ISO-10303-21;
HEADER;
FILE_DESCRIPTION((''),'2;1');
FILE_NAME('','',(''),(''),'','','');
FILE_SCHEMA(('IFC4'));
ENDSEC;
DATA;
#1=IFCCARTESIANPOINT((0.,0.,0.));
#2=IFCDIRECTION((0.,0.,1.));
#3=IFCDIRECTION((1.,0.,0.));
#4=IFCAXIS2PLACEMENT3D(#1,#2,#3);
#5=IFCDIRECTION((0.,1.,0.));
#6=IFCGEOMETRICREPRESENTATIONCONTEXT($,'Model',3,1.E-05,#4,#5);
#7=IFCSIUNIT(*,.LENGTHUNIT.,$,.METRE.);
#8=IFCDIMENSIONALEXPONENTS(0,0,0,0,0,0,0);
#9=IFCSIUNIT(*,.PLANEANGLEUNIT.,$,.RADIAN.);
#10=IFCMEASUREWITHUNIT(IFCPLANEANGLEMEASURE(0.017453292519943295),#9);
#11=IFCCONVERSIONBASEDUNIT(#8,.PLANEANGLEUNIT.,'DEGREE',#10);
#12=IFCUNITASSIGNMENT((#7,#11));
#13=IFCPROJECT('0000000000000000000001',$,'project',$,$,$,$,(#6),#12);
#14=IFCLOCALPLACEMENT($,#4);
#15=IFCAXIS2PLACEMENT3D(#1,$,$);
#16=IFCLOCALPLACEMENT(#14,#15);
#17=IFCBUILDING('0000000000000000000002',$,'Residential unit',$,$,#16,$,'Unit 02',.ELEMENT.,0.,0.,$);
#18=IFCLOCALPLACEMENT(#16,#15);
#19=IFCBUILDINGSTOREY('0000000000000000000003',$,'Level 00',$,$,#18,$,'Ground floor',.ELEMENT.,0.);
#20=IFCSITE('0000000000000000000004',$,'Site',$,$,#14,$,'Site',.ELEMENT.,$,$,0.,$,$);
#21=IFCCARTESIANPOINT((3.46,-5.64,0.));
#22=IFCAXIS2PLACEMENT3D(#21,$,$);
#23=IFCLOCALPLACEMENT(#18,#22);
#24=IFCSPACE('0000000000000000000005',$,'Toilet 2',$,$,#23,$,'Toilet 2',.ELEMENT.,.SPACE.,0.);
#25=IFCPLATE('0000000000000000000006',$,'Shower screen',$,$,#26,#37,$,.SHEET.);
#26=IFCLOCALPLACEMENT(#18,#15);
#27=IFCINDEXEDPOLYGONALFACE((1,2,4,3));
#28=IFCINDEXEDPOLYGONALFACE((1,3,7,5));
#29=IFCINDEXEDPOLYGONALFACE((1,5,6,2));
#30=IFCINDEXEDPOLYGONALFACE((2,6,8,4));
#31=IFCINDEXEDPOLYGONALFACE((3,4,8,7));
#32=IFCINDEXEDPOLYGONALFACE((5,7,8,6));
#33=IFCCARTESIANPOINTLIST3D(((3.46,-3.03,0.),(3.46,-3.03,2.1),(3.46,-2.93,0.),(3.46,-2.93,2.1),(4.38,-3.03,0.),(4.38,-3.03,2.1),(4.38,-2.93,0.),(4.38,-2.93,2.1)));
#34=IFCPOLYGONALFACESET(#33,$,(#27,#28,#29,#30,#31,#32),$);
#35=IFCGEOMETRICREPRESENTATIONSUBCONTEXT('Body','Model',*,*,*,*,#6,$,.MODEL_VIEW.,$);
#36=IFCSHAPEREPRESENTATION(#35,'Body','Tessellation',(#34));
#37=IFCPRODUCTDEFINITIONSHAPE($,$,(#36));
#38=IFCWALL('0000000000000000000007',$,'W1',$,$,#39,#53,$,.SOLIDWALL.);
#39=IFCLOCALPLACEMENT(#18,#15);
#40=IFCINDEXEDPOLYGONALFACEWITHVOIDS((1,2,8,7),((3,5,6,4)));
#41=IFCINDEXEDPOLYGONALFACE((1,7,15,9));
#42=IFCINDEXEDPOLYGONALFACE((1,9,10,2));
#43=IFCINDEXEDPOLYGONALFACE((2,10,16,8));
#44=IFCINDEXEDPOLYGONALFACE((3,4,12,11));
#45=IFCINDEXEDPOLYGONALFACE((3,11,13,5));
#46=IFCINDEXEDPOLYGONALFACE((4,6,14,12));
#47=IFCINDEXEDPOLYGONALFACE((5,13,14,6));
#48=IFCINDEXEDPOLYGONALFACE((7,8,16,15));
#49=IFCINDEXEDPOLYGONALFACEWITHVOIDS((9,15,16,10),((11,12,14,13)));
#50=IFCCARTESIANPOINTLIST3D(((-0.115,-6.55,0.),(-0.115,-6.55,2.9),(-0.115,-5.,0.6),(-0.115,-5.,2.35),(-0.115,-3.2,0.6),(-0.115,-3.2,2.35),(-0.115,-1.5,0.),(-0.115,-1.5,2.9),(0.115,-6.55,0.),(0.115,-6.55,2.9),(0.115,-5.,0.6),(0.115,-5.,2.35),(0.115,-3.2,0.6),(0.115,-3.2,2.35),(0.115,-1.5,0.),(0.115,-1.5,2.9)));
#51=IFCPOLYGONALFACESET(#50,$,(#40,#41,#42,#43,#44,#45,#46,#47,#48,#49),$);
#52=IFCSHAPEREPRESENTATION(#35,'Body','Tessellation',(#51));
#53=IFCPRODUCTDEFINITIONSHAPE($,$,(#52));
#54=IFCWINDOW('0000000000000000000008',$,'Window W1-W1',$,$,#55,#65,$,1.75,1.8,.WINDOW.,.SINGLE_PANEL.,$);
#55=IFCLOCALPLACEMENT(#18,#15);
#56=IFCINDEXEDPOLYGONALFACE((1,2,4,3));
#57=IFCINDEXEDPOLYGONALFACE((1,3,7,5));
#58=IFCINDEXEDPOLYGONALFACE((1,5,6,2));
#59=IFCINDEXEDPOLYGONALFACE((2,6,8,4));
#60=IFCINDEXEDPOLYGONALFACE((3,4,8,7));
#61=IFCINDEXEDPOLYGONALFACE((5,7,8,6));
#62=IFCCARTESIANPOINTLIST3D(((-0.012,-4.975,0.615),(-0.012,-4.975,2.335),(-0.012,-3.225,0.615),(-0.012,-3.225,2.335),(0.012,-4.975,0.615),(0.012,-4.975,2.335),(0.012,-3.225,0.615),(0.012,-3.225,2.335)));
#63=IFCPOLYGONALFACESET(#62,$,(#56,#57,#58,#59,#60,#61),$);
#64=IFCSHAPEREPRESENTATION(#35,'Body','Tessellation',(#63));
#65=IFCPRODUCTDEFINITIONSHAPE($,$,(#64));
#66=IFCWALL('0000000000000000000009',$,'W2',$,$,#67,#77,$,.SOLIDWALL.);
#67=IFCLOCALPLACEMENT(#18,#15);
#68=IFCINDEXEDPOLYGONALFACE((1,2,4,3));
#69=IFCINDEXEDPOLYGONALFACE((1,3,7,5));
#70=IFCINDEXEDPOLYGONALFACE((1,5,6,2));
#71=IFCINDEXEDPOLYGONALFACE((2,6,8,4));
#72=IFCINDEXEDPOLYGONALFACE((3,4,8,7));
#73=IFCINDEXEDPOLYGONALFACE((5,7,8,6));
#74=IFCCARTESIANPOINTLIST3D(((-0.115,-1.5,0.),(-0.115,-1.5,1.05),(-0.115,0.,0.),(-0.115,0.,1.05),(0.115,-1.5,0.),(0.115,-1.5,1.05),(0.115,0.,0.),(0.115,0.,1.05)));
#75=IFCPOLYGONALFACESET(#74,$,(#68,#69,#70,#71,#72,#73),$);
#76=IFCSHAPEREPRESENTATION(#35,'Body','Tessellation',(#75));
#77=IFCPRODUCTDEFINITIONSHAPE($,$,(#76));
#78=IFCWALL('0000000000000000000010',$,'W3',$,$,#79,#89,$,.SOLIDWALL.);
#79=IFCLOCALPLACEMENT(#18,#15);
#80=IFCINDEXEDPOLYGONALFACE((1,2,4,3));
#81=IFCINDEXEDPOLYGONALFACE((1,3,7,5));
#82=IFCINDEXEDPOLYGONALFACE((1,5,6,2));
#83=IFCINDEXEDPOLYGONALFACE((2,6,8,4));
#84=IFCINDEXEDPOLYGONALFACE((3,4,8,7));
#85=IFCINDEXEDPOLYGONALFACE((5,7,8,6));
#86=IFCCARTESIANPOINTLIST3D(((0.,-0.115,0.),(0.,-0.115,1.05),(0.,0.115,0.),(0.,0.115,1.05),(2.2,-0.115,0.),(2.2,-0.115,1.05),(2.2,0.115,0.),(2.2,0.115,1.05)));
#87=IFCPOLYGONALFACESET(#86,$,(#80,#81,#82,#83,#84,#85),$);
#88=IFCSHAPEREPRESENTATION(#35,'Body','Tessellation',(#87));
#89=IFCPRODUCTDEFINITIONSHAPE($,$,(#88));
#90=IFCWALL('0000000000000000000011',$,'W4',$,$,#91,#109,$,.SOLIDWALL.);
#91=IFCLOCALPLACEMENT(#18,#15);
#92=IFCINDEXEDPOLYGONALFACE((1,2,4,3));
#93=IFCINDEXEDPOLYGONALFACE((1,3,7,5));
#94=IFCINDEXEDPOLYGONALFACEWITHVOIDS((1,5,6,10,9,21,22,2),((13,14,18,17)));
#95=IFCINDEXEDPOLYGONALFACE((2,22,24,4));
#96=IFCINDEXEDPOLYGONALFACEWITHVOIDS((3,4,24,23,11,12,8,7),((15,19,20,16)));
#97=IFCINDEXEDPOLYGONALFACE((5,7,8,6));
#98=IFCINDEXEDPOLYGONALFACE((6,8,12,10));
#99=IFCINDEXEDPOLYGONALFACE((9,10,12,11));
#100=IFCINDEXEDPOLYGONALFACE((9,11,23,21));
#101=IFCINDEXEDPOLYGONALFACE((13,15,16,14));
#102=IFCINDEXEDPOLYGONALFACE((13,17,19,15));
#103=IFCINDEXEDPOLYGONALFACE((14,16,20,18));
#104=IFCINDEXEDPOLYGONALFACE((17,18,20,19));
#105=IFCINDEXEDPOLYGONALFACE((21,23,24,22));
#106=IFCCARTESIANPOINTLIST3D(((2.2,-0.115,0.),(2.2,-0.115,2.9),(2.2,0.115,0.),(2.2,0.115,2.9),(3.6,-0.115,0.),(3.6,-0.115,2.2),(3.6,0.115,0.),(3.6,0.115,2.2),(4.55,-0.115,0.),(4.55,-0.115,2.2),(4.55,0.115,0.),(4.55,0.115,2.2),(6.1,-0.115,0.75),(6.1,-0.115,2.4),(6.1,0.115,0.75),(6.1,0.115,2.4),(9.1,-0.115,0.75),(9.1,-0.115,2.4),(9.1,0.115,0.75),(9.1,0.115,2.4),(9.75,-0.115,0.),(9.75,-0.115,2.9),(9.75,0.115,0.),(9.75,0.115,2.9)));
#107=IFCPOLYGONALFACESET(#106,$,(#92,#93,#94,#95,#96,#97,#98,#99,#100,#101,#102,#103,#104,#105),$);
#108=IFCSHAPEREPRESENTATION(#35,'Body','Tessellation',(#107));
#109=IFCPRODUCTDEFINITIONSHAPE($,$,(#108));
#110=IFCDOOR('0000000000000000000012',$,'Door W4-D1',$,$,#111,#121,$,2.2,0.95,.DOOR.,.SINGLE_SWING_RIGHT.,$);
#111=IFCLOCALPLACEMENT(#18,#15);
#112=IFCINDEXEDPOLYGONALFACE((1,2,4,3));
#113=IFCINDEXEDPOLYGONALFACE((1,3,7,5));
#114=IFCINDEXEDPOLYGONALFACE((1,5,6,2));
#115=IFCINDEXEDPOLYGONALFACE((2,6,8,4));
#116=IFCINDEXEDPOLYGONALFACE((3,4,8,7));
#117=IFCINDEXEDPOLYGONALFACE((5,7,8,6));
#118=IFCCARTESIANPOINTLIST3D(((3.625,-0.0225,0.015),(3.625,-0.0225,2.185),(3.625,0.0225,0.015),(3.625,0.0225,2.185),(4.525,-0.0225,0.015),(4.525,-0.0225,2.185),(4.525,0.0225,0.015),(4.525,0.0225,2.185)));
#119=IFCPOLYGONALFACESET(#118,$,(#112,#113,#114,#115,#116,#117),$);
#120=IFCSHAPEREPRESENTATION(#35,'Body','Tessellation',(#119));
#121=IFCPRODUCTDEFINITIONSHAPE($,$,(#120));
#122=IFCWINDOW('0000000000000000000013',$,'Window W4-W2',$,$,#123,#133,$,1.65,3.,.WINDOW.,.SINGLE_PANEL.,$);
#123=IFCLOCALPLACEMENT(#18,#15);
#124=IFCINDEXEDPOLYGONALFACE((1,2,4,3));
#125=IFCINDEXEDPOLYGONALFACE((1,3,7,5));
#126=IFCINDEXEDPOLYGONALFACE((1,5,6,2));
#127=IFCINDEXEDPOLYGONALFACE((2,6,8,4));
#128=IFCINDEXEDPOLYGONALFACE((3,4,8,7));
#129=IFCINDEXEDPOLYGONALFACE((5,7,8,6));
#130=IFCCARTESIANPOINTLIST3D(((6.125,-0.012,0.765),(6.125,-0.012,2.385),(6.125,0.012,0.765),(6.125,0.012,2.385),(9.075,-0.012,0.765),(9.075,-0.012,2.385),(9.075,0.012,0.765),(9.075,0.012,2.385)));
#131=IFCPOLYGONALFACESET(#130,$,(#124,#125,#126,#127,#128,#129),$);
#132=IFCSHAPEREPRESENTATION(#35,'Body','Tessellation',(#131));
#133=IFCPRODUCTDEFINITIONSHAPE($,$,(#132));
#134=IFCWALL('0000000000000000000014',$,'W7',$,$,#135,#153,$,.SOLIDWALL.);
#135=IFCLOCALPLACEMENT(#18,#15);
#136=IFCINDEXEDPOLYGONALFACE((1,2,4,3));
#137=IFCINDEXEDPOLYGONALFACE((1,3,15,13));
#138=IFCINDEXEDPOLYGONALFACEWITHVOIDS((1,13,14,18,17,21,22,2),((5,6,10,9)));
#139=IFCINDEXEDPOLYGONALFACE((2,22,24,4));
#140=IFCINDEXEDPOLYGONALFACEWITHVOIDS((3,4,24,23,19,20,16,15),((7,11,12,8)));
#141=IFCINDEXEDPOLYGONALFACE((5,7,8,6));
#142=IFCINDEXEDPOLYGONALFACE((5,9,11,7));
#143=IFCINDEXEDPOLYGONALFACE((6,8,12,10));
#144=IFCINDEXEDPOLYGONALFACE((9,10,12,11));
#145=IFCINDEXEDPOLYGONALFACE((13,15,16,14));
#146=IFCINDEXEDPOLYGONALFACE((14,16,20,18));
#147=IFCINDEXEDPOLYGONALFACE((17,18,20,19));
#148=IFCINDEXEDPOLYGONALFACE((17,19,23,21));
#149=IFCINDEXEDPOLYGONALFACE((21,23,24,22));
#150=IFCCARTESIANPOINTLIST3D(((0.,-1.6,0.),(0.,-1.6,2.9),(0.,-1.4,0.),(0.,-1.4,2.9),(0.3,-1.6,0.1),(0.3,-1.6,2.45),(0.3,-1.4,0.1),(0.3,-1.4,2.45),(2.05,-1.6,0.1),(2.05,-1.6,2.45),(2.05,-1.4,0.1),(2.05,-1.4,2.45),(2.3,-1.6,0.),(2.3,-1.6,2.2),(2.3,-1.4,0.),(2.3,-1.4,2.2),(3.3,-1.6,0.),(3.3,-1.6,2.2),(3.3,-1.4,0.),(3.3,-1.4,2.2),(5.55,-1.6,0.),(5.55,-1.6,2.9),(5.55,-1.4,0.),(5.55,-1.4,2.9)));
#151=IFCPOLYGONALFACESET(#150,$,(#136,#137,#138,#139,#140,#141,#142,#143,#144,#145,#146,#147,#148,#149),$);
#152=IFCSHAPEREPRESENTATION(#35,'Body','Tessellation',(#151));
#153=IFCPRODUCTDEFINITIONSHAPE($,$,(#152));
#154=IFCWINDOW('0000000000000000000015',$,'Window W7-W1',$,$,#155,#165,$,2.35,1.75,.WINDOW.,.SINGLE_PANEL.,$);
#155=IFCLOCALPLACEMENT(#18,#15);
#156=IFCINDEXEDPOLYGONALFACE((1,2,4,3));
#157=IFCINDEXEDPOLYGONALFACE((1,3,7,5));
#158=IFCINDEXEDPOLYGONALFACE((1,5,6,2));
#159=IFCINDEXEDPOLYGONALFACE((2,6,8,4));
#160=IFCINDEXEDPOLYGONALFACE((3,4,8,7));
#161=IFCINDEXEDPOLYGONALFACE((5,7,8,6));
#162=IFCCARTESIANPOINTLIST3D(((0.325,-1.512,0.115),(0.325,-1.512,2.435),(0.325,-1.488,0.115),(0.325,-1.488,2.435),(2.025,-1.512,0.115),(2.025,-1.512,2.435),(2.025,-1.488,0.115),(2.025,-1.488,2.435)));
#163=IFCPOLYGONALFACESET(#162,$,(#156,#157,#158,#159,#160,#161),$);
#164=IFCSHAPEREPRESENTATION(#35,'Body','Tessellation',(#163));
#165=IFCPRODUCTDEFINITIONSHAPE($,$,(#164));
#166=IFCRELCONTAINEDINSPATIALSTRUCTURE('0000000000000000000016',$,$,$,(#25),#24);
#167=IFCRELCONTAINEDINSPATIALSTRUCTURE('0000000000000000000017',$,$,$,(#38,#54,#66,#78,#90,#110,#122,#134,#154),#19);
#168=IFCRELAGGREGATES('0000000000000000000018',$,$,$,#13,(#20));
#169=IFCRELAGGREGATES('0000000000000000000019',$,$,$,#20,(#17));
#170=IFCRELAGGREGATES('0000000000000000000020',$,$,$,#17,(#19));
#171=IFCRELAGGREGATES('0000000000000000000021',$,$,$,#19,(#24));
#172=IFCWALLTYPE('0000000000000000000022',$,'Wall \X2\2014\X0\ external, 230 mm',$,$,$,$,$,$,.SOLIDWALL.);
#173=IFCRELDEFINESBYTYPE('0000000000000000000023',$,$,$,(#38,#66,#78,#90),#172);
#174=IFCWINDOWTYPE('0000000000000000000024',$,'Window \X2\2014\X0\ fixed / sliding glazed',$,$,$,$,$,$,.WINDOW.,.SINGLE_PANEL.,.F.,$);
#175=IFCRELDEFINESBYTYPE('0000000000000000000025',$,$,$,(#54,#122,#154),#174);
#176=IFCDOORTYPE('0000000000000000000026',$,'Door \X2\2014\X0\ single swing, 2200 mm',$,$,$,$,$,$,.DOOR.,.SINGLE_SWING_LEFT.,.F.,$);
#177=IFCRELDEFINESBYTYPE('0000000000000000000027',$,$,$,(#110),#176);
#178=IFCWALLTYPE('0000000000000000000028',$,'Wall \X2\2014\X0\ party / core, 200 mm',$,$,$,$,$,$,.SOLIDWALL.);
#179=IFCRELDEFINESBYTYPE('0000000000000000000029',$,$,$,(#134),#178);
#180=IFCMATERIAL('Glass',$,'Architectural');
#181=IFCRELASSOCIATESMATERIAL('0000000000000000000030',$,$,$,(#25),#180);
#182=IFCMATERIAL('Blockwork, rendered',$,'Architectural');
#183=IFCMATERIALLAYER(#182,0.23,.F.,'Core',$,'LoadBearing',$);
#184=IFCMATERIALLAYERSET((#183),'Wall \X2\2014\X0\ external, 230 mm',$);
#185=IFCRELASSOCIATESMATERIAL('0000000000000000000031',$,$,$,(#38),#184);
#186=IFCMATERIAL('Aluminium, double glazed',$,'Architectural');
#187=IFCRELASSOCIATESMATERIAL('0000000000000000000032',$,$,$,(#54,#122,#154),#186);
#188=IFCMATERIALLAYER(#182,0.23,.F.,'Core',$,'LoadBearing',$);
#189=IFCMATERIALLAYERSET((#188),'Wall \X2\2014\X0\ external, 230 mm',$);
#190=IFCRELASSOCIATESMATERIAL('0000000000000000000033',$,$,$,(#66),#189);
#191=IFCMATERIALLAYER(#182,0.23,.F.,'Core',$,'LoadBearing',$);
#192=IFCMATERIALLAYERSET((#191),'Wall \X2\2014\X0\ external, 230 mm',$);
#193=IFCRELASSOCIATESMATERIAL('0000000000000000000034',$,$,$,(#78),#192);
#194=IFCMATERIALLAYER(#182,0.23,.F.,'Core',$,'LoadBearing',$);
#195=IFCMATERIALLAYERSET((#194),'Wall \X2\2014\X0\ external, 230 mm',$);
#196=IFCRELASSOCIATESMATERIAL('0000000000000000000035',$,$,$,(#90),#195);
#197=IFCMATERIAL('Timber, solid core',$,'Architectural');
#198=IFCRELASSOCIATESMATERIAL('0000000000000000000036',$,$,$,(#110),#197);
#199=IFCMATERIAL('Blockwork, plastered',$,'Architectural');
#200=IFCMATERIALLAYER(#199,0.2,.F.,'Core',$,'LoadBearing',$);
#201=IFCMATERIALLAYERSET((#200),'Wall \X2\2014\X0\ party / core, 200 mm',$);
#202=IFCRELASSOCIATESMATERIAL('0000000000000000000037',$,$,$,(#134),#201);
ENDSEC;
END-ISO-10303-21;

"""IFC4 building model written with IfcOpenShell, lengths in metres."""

from ifc_helpers import new_model, entity, si_unit, converted_unit, direction, frame, frame_2d, origin, origin_with_axes, origin_2d, place, context, subcontext, project, spatial, rectangle, extrude, material, layer, layer_set, layer_usage, type_object, element, fill, save


model = new_model("IFC4")

# Units and contexts
model_context = context("Model", 3, precision=1e-05, world=origin_with_axes(), true_north=direction((0.0, 1.0, 0.0)))
body_context = subcontext(model_context, "Body", "Model", "MODEL_VIEW")
ifc_project = project(units=[si_unit("LENGTHUNIT", "METRE"), converted_unit("PLANEANGLEUNIT", "DEGREE", entity("IfcPlaneAngleMeasure", 0.017453292519943295), si_unit("PLANEANGLEUNIT", "RADIAN"), dimensions=[0, 0, 0, 0, 0, 0, 0])], contexts=[model_context])

# Site, building, storey, space
site_placement = place(None, origin_with_axes())
site = spatial("IfcSite", under=ifc_project, at=site_placement, Name="Site", LongName="Site", CompositionType="ELEMENT", RefElevation=0.0)
building_placement = place(site_placement, origin())
building = spatial("IfcBuilding", under=site, at=building_placement, Name="Residential unit", LongName="Unit 02", CompositionType="ELEMENT", ElevationOfRefHeight=0.0, ElevationOfTerrain=0.0)
storey_placement = place(building_placement, origin())
storey = spatial("IfcBuildingStorey", under=building, at=storey_placement, Name="Level 00", LongName="Ground floor", CompositionType="ELEMENT", Elevation=0.0)
space_1_placement = place(storey_placement, frame((3.46, -5.64, 0.0)))
space_1 = spatial("IfcSpace", under=storey, at=space_1_placement, Name="Toilet 2", LongName="Toilet 2", CompositionType="ELEMENT", PredefinedType="SPACE", ElevationWithFlooring=0.0)

# Plate
ifc_material_1 = material(Name="Glass", Category="Architectural")
plate_placement = place(storey_placement, frame((3.46, -3.03, 0.0)))
element("IfcPlate", 1, at=plate_placement, inside=space_1, material=ifc_material_1, Name="Shower screen", PredefinedType="SHEET", context=body_context, shape_type="SweptSolid", body=[
    extrude(rectangle(XDim=0.92, YDim=0.1, at=frame_2d((0.46, 0.05))), origin(), (0.0, 0.0, 1.0), 2.1),
])

# Wall, opening, window
ifc_material_2 = material(Name="Blockwork, rendered", Category="Architectural")
ifc_layer_1 = layer(ifc_material_2, 0.23, ventilated=False, Name="Core", Category="LoadBearing")
ifc_layer_set_1 = layer_set([ifc_layer_1], Name="Wall — external, 230 mm")
ifc_layer_usage_1 = layer_usage(ifc_layer_set_1, "AXIS2", "POSITIVE", -0.115)
wall_type_1 = type_object("IfcWallType", Name="Wall — external, 230 mm", PredefinedType="SOLIDWALL")
wall_1_placement = place(storey_placement, frame((0.0, -1.5, 0.0), z_axis=(0.0, 0.0, 1.0), x_axis=(0.0, -1.0, 0.0)))
wall_1 = element("IfcWall", 2, at=wall_1_placement, inside=storey, type_object=wall_type_1, material=ifc_layer_usage_1, Name="W1", PredefinedType="SOLIDWALL", context=body_context, shape_type="SweptSolid", body=[
    extrude(rectangle(XDim=5.05, YDim=0.23, at=frame_2d((2.525, 0.0))), origin(), (0.0, 0.0, 1.0), 2.9),
])
opening_1_placement = place(wall_1_placement, frame((2.6, 0.0, 0.6)))
opening_1 = element("IfcOpeningElement", 3, at=opening_1_placement, cuts=wall_1, PredefinedType="OPENING", context=body_context, shape_type="SweptSolid", body=[
    extrude(rectangle(XDim=1.8, YDim=0.29, at=origin_2d()), origin(), (0.0, 0.0, 1.0), 1.75),
])
ifc_material_3 = material(Name="Aluminium, double glazed", Category="Architectural")
window_type = type_object("IfcWindowType", Name="Window — fixed / sliding glazed", ParameterTakesPrecedence=False, PartitioningType="SINGLE_PANEL", PredefinedType="WINDOW")
window_1_placement = place(wall_1_placement, frame((2.6, 0.0, 0.6)))
window_1 = element("IfcWindow", 4, at=window_1_placement, inside=storey, type_object=window_type, material=ifc_material_3, Name="Window W1-W1", OverallHeight=1.75, OverallWidth=1.8, PartitioningType="SINGLE_PANEL", PredefinedType="WINDOW", context=body_context, shape_type="SweptSolid", body=[
    extrude(rectangle(XDim=1.75, YDim=0.024, at=origin_2d()), frame((0.0, 0.0, 0.015)), (0.0, 0.0, 1.0), 1.72),
])
fill(opening_1, window_1)

# Walls
ifc_layer_2 = layer(ifc_material_2, 0.23, ventilated=False, Name="Core", Category="LoadBearing")
ifc_layer_set_2 = layer_set([ifc_layer_2], Name="Wall — external, 230 mm")
ifc_layer_usage_2 = layer_usage(ifc_layer_set_2, "AXIS2", "POSITIVE", -0.115)
wall_2_placement = place(storey_placement, frame((0.0, 0.0, 0.0), z_axis=(0.0, 0.0, 1.0), x_axis=(0.0, -1.0, 0.0)))
element("IfcWall", 5, at=wall_2_placement, inside=storey, type_object=wall_type_1, material=ifc_layer_usage_2, Name="W2", PredefinedType="SOLIDWALL", context=body_context, shape_type="SweptSolid", body=[
    extrude(rectangle(XDim=1.5, YDim=0.23, at=frame_2d((0.75, 0.0))), origin(), (0.0, 0.0, 1.0), 1.05),
])
ifc_layer_3 = layer(ifc_material_2, 0.23, ventilated=False, Name="Core", Category="LoadBearing")
ifc_layer_set_3 = layer_set([ifc_layer_3], Name="Wall — external, 230 mm")
ifc_layer_usage_3 = layer_usage(ifc_layer_set_3, "AXIS2", "POSITIVE", -0.115)
wall_3_placement = place(storey_placement, origin_with_axes())
element("IfcWall", 6, at=wall_3_placement, inside=storey, type_object=wall_type_1, material=ifc_layer_usage_3, Name="W3", PredefinedType="SOLIDWALL", context=body_context, shape_type="SweptSolid", body=[
    extrude(rectangle(XDim=2.2, YDim=0.23, at=frame_2d((1.1, 0.0))), origin(), (0.0, 0.0, 1.0), 1.05),
])

# Wall, openings, door, window
ifc_layer_4 = layer(ifc_material_2, 0.23, ventilated=False, Name="Core", Category="LoadBearing")
ifc_layer_set_4 = layer_set([ifc_layer_4], Name="Wall — external, 230 mm")
ifc_layer_usage_4 = layer_usage(ifc_layer_set_4, "AXIS2", "POSITIVE", -0.115)
wall_4_placement = place(storey_placement, frame((2.2, 0.0, 0.0), z_axis=(0.0, 0.0, 1.0), x_axis=(1.0, 0.0, 0.0)))
wall_4 = element("IfcWall", 7, at=wall_4_placement, inside=storey, type_object=wall_type_1, material=ifc_layer_usage_4, Name="W4", PredefinedType="SOLIDWALL", context=body_context, shape_type="SweptSolid", body=[
    extrude(rectangle(XDim=7.55, YDim=0.23, at=frame_2d((3.775, 0.0))), origin(), (0.0, 0.0, 1.0), 2.9),
])
opening_2_placement = place(wall_4_placement, frame((1.875, 0.0, 0.0)))
opening_2 = element("IfcOpeningElement", 8, at=opening_2_placement, cuts=wall_4, PredefinedType="OPENING", context=body_context, shape_type="SweptSolid", body=[
    extrude(rectangle(XDim=0.95, YDim=0.29, at=origin_2d()), origin(), (0.0, 0.0, 1.0), 2.2),
])
opening_3_placement = place(wall_4_placement, frame((5.4, 0.0, 0.75)))
opening_3 = element("IfcOpeningElement", 9, at=opening_3_placement, cuts=wall_4, PredefinedType="OPENING", context=body_context, shape_type="SweptSolid", body=[
    extrude(rectangle(XDim=3.0, YDim=0.29, at=origin_2d()), origin(), (0.0, 0.0, 1.0), 1.65),
])
ifc_material_4 = material(Name="Timber, solid core", Category="Architectural")
door_type = type_object("IfcDoorType", Name="Door — single swing, 2200 mm", OperationType="SINGLE_SWING_LEFT", ParameterTakesPrecedence=False, PredefinedType="DOOR")
door_placement = place(wall_4_placement, frame((1.875, 0.0, 0.0)))
door = element("IfcDoor", 10, at=door_placement, inside=storey, type_object=door_type, material=ifc_material_4, Name="Door W4-D1", OperationType="SINGLE_SWING_RIGHT", OverallHeight=2.2, OverallWidth=0.95, PredefinedType="DOOR", context=body_context, shape_type="SweptSolid", body=[
    extrude(rectangle(XDim=0.9, YDim=0.045, at=origin_2d()), frame((0.0, 0.0, 0.015)), (0.0, 0.0, 1.0), 2.17),
])
fill(opening_2, door)
window_2_placement = place(wall_4_placement, frame((5.4, 0.0, 0.75)))
window_2 = element("IfcWindow", 11, at=window_2_placement, inside=storey, type_object=window_type, material=ifc_material_3, Name="Window W4-W2", OverallHeight=1.65, OverallWidth=3.0, PartitioningType="SINGLE_PANEL", PredefinedType="WINDOW", context=body_context, shape_type="SweptSolid", body=[
    extrude(rectangle(XDim=2.95, YDim=0.024, at=origin_2d()), frame((0.0, 0.0, 0.015)), (0.0, 0.0, 1.0), 1.62),
])
fill(opening_3, window_2)

# Wall, openings, window
ifc_material_5 = material(Name="Blockwork, plastered", Category="Architectural")
ifc_layer_5 = layer(ifc_material_5, 0.2, ventilated=False, Name="Core", Category="LoadBearing")
ifc_layer_set_5 = layer_set([ifc_layer_5], Name="Wall — party / core, 200 mm")
ifc_layer_usage_5 = layer_usage(ifc_layer_set_5, "AXIS2", "POSITIVE", -0.1)
wall_type_2 = type_object("IfcWallType", Name="Wall — party / core, 200 mm", PredefinedType="SOLIDWALL")
wall_5_placement = place(storey_placement, frame((0.0, -1.5, 0.0), z_axis=(0.0, 0.0, 1.0), x_axis=(1.0, 0.0, 0.0)))
wall_5 = element("IfcWall", 12, at=wall_5_placement, inside=storey, type_object=wall_type_2, material=ifc_layer_usage_5, Name="W7", PredefinedType="SOLIDWALL", context=body_context, shape_type="SweptSolid", body=[
    extrude(rectangle(XDim=5.55, YDim=0.2, at=frame_2d((2.775, 0.0))), origin(), (0.0, 0.0, 1.0), 2.9),
])
opening_4_placement = place(wall_5_placement, frame((1.175, 0.0, 0.1)))
opening_4 = element("IfcOpeningElement", 13, at=opening_4_placement, cuts=wall_5, PredefinedType="OPENING", context=body_context, shape_type="SweptSolid", body=[
    extrude(rectangle(XDim=1.75, YDim=0.26, at=origin_2d()), origin(), (0.0, 0.0, 1.0), 2.35),
])
opening_5_placement = place(wall_5_placement, frame((2.8, 0.0, 0.0)))
element("IfcOpeningElement", 14, at=opening_5_placement, cuts=wall_5, PredefinedType="OPENING", context=body_context, shape_type="SweptSolid", body=[
    extrude(rectangle(XDim=1.0, YDim=0.26, at=origin_2d()), origin(), (0.0, 0.0, 1.0), 2.2),
])
window_3_placement = place(wall_5_placement, frame((1.175, 0.0, 0.1)))
window_3 = element("IfcWindow", 15, at=window_3_placement, inside=storey, type_object=window_type, material=ifc_material_3, Name="Window W7-W1", OverallHeight=2.35, OverallWidth=1.75, PartitioningType="SINGLE_PANEL", PredefinedType="WINDOW", context=body_context, shape_type="SweptSolid", body=[
    extrude(rectangle(XDim=1.7, YDim=0.024, at=origin_2d()), frame((0.0, 0.0, 0.015)), (0.0, 0.0, 1.0), 2.32),
])
fill(opening_4, window_3)

save(model, "model.ifc")
